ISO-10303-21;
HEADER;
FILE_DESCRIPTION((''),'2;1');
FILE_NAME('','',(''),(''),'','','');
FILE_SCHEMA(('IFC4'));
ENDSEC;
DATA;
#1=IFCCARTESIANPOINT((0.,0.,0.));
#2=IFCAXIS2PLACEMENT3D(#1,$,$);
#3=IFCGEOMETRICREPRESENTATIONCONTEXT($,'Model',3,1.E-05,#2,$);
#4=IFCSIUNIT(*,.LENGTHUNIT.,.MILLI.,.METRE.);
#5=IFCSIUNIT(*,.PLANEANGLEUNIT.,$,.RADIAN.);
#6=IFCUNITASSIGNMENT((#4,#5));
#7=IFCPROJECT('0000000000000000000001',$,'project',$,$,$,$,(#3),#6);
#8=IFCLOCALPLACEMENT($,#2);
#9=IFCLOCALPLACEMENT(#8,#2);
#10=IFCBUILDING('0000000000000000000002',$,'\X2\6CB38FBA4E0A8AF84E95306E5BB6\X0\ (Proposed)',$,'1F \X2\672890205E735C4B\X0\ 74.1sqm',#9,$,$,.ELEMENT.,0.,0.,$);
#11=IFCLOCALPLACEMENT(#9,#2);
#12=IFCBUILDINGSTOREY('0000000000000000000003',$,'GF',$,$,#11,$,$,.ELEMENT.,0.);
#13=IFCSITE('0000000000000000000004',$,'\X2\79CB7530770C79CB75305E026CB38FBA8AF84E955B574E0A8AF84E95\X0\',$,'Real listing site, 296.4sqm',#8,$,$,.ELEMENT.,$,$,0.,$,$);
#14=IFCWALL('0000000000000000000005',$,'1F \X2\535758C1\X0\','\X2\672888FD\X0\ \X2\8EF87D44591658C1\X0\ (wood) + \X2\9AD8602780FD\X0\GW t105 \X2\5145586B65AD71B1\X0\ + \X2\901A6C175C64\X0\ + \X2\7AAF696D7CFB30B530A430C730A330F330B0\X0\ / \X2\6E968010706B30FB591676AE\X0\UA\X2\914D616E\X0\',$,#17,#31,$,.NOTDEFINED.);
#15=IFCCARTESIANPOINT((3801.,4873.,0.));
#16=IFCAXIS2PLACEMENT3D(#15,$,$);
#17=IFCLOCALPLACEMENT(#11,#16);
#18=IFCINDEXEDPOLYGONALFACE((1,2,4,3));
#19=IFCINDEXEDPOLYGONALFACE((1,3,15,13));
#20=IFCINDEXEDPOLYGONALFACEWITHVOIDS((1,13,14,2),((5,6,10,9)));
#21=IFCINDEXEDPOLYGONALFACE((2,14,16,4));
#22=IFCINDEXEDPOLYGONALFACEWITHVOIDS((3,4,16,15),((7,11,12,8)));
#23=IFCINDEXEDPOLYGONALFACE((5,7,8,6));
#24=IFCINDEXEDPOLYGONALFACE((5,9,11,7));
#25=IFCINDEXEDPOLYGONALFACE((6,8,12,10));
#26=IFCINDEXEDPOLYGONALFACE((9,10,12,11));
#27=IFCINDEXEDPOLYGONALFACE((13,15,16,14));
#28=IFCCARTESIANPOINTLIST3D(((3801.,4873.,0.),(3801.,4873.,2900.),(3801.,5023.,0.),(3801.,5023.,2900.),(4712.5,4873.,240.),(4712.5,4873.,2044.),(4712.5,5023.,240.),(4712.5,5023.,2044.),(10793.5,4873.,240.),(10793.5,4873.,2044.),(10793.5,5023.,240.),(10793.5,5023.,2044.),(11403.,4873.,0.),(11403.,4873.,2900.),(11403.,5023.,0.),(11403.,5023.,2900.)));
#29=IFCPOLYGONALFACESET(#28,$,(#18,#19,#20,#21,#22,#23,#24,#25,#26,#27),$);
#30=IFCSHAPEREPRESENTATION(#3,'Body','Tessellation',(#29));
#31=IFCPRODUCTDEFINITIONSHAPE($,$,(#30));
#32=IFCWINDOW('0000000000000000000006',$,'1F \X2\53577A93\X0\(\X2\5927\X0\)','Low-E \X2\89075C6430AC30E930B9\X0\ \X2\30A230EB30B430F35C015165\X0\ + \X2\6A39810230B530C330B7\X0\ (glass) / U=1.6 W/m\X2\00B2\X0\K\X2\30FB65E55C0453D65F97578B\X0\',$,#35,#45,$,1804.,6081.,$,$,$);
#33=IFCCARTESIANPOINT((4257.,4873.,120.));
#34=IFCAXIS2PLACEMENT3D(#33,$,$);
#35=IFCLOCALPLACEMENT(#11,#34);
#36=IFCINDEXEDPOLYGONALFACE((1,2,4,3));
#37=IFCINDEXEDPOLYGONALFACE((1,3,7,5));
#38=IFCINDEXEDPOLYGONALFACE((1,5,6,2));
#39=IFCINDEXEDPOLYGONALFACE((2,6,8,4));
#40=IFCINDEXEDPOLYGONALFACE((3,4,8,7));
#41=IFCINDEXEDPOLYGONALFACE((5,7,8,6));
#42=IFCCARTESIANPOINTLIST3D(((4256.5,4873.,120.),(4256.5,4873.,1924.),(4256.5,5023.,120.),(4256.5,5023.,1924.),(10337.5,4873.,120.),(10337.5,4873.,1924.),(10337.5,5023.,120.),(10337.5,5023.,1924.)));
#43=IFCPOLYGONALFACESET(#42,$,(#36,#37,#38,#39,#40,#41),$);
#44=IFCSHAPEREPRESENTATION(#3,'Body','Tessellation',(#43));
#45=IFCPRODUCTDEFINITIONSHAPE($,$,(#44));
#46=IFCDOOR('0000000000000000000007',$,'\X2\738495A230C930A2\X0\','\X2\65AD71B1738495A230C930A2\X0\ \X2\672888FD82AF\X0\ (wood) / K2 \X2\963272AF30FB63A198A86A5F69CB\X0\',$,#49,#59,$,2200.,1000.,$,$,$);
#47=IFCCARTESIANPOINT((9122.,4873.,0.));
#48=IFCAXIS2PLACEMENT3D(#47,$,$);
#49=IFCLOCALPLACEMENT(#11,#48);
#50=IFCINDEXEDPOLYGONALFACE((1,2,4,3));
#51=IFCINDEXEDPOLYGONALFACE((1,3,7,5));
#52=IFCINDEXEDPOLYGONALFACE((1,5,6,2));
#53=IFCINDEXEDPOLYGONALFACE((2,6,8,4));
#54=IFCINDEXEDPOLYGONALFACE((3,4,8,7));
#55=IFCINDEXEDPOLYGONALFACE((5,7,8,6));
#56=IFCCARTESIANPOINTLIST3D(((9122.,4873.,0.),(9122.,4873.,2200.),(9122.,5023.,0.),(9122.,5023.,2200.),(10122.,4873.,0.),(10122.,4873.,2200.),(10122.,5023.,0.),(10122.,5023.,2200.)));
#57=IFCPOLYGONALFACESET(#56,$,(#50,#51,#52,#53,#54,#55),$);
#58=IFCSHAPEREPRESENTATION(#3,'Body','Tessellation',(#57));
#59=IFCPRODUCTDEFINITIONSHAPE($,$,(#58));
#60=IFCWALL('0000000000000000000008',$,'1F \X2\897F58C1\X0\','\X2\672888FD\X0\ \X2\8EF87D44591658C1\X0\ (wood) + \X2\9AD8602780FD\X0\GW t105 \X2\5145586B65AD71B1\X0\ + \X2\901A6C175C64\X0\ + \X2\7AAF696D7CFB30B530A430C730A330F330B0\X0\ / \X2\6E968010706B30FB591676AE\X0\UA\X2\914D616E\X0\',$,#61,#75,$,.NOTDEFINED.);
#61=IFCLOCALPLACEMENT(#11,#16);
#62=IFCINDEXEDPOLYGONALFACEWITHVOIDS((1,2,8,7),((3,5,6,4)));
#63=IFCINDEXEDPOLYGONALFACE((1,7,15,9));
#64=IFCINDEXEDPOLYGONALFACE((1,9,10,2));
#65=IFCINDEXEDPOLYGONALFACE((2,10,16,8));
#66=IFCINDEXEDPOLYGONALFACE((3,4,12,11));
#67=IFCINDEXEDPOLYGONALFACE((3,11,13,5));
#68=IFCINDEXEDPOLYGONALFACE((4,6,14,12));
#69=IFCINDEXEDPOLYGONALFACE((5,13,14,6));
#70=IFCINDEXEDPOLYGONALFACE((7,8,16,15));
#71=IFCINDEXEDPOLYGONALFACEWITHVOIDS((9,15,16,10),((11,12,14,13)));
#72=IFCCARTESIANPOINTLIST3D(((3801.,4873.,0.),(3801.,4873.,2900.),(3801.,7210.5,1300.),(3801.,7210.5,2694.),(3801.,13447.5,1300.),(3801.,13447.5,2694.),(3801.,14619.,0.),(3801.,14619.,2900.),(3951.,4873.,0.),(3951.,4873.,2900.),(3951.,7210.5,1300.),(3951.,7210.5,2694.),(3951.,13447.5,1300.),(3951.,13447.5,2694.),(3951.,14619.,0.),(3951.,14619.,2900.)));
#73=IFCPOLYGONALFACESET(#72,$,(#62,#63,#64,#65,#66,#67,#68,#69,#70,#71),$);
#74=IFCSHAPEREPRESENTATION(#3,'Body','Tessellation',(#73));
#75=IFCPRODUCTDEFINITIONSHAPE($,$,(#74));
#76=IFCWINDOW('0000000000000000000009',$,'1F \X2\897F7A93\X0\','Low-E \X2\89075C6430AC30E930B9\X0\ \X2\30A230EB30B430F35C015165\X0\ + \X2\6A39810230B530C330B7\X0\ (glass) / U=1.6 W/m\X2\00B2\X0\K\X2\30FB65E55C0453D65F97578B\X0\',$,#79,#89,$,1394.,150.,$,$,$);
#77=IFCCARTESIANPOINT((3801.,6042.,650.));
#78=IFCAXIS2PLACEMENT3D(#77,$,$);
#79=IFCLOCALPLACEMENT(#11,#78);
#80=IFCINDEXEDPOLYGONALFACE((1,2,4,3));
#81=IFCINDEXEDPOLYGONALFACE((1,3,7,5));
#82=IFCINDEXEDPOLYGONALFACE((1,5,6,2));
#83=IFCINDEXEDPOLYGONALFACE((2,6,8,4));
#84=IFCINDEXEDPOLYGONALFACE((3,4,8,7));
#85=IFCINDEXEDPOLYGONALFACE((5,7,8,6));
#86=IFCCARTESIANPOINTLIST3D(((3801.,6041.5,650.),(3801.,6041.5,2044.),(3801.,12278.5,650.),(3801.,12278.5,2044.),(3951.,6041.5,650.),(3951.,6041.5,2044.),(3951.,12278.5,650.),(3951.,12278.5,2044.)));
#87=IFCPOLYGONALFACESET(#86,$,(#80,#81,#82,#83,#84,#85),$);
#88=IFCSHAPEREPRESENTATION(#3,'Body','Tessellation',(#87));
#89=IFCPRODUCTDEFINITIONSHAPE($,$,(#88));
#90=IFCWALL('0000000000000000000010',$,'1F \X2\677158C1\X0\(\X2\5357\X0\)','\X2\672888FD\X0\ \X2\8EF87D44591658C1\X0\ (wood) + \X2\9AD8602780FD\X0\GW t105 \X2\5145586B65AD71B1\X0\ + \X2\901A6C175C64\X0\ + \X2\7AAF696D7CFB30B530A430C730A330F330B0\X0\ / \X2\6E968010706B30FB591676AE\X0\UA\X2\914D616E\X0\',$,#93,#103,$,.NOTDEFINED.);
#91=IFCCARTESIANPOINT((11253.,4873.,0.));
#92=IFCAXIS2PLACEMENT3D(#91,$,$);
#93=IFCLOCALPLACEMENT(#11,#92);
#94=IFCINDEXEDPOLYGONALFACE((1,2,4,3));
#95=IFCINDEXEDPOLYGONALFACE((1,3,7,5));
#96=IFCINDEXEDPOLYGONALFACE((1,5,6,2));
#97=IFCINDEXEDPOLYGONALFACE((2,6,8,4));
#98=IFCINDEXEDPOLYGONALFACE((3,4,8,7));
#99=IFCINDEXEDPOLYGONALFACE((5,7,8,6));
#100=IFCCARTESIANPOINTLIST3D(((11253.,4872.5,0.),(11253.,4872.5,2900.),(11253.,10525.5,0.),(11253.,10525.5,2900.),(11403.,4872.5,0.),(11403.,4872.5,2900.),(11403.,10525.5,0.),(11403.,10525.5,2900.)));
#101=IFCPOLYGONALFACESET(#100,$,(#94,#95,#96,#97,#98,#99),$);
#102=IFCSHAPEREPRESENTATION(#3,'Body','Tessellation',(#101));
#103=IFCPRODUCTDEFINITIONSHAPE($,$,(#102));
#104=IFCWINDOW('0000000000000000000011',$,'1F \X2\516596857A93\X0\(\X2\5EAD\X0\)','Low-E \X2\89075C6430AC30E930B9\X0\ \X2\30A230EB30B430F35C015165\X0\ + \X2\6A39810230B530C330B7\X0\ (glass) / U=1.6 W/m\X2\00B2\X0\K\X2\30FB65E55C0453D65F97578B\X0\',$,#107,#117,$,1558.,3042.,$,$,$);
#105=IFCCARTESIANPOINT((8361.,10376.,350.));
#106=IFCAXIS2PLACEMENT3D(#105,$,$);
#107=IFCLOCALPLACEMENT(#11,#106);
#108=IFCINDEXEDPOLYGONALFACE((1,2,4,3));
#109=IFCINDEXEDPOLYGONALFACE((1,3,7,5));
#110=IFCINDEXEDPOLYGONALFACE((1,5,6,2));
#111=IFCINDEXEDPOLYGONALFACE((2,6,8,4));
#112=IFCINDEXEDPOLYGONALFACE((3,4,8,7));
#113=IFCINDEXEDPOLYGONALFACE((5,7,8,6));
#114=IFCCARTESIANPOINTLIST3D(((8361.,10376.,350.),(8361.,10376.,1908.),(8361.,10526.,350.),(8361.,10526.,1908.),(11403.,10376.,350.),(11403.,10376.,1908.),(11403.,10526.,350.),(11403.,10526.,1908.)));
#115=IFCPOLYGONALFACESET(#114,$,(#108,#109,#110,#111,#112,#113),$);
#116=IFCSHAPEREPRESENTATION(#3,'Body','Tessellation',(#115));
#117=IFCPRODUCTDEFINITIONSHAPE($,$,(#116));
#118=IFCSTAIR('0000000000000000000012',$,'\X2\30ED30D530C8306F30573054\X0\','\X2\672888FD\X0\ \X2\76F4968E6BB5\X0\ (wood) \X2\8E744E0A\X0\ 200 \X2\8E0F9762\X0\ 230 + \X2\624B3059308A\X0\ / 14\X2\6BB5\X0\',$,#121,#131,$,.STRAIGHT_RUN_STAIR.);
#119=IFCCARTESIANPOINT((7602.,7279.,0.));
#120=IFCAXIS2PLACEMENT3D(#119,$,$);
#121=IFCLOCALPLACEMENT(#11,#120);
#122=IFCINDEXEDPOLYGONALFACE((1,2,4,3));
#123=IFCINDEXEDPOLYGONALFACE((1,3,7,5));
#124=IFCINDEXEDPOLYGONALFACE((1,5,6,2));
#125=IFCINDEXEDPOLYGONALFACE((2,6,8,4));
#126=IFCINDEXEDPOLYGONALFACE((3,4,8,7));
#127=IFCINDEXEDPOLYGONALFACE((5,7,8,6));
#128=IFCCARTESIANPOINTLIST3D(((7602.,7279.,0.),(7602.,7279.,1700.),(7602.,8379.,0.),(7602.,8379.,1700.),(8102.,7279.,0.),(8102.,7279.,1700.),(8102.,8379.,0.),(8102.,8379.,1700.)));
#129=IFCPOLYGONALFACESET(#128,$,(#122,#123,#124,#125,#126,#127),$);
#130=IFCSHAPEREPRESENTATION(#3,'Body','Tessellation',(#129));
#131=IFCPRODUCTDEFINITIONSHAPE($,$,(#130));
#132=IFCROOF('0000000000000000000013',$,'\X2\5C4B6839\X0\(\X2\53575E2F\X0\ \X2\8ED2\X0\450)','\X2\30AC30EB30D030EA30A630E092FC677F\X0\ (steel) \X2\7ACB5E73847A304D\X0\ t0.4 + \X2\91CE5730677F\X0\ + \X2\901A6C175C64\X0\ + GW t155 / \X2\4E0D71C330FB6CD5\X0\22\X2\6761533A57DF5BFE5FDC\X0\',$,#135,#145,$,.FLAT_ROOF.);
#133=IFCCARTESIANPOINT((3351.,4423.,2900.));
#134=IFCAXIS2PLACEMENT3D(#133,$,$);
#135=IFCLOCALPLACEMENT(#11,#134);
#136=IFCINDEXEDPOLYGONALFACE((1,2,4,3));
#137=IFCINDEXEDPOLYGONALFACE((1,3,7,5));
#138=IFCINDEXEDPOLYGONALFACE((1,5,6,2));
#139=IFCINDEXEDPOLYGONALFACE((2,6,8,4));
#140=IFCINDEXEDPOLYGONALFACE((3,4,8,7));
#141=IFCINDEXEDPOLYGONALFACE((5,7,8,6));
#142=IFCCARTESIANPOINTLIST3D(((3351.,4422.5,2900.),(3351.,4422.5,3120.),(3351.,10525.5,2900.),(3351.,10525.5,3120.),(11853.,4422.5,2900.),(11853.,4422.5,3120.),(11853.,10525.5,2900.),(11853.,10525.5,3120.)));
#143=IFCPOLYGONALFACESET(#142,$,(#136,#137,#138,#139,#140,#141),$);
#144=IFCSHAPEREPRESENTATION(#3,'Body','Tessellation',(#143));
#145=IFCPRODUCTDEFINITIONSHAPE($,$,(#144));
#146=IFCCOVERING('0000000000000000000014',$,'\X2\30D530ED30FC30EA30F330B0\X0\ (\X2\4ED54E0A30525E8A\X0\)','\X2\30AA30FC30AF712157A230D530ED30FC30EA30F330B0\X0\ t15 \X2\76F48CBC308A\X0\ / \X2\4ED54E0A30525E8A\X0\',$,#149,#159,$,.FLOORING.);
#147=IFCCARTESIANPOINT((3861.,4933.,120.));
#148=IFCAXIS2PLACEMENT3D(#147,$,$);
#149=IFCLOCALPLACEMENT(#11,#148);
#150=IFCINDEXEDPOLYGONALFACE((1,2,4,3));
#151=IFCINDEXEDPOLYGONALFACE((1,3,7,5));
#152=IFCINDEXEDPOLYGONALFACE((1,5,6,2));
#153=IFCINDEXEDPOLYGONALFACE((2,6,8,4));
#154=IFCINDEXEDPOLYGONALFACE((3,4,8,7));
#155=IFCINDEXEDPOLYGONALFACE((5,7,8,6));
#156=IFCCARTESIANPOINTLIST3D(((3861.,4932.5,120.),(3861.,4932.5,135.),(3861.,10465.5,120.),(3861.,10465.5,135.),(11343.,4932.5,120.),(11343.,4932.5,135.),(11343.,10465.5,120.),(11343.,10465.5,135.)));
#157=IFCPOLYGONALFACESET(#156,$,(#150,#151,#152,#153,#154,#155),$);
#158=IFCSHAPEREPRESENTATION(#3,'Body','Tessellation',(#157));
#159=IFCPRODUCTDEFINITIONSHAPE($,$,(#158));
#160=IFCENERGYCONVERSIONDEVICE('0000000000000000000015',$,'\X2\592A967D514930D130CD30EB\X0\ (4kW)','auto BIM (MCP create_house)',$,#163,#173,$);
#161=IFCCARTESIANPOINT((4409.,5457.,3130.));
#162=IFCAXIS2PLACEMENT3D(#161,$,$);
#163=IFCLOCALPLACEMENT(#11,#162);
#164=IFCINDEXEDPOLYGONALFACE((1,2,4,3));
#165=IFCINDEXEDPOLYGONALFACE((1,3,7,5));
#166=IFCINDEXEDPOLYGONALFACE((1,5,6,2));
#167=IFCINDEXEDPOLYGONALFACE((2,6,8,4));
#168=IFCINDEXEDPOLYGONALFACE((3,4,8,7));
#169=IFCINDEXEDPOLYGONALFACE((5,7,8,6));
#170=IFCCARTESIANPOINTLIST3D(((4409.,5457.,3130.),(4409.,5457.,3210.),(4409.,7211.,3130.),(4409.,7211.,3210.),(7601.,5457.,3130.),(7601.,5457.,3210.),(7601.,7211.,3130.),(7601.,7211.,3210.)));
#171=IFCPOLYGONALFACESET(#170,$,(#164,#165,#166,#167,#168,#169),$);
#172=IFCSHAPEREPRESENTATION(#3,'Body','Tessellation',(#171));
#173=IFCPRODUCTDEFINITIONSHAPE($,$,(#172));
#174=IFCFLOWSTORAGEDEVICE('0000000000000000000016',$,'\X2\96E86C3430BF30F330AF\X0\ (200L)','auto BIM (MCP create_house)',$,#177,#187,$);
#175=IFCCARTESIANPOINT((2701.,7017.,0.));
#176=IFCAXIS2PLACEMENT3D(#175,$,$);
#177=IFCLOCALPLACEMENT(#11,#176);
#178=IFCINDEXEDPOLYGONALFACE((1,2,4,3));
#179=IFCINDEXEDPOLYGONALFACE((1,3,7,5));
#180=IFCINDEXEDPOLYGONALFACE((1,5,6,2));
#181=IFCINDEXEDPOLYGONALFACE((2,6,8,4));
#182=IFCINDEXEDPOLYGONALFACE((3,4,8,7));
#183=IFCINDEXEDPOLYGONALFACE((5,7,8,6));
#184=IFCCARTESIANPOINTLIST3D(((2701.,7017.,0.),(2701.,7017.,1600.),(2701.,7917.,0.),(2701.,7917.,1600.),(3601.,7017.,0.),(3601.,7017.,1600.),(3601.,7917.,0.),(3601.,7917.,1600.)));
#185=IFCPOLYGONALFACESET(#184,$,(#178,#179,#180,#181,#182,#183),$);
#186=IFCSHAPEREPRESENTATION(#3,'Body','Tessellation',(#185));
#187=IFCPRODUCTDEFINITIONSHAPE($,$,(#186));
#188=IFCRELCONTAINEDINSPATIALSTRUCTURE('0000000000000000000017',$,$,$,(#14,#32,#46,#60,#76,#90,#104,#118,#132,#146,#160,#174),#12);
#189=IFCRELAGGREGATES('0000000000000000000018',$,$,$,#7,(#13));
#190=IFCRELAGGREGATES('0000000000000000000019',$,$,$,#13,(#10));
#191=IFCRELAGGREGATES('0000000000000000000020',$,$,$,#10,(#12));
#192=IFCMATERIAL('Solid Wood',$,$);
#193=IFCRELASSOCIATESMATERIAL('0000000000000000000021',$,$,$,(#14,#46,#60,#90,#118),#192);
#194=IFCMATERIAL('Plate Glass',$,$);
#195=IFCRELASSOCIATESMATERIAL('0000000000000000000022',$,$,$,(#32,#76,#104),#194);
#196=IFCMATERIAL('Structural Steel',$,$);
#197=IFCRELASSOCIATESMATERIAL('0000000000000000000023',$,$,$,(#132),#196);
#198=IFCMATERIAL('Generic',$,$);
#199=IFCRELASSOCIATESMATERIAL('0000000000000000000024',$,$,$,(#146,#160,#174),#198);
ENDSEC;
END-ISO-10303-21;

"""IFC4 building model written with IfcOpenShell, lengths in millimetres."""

from ifc_helpers import new_model, si_unit, frame, frame_2d, origin, place, context, project, spatial, rectangle, extrude, material, element, fill, save


model = new_model("IFC4")

# Units and contexts
model_context = context("Model", 3, precision=1e-05, world=origin())
ifc_project = project(units=[si_unit("LENGTHUNIT", "METRE", prefix="MILLI"), si_unit("PLANEANGLEUNIT", "RADIAN")], contexts=[model_context])

# Site, building, storey
site_placement = place(None, origin())
site = spatial("IfcSite", under=ifc_project, at=site_placement, Name="秋田県秋田市河辺諸井字上諸井", ObjectType="Real listing site, 296.4sqm", CompositionType="ELEMENT", RefElevation=0.0)
building_placement = place(site_placement, origin())
building = spatial("IfcBuilding", under=site, at=building_placement, Name="河辺上諸井の家 (Proposed)", ObjectType="1F 木造平屋 74.1sqm", CompositionType="ELEMENT", ElevationOfRefHeight=0.0, ElevationOfTerrain=0.0)
storey_placement = place(building_placement, origin())
storey = spatial("IfcBuildingStorey", under=building, at=storey_placement, Name="GF", CompositionType="ELEMENT", Elevation=0.0)

# Shared definitions
ifc_material_1 = material(Name="Solid Wood")

# Wall, openings, window, door
wall_1_placement = place(storey_placement, frame((3801.0, 4873.0, 0.0)))
wall_1 = element("IfcWall", 1, at=wall_1_placement, inside=storey, material=ifc_material_1, Name="1F 南壁", Description="木製 軸組外壁 (wood) + 高性能GW t105 充填断熱 + 通気層 + 窯業系サイディング / 準耐火・外皮UA配慮", PredefinedType="NOTDEFINED", context=model_context, shape_type="SweptSolid", body=[
    extrude(rectangle(XDim=7602.0, YDim=150.0, at=frame_2d((3801.0, 75.0))), frame((3801.0, 4873.0, 0.0)), (0.0, 0.0, 1.0), 2900.0),
])
opening_1_placement = place(storey_placement, frame((4257.0, 4873.0, 120.0)))
opening_1 = element("IfcOpeningElement", 2, at=opening_1_placement, cuts=wall_1, PredefinedType="NOTDEFINED", context=model_context, shape_type="SweptSolid", body=[
    extrude(rectangle(XDim=6081.0, YDim=150.0, at=frame_2d((3040.0, 75.0))), frame((4257.0, 4873.0, 120.0)), (0.0, 0.0, 1.0), 1804.0),
])
opening_2_placement = place(storey_placement, frame((9122.0, 4873.0, 0.0)))
opening_2 = element("IfcOpeningElement", 3, at=opening_2_placement, cuts=wall_1, PredefinedType="NOTDEFINED", context=model_context, shape_type="SweptSolid", body=[
    extrude(rectangle(XDim=1000.0, YDim=150.0, at=frame_2d((500.0, 75.0))), frame((9122.0, 4873.0, 0.0)), (0.0, 0.0, 1.0), 2200.0),
])
ifc_material_2 = material(Name="Plate Glass")
window_1_placement = place(storey_placement, frame((4257.0, 4873.0, 120.0)))
window_1 = element("IfcWindow", 4, at=window_1_placement, inside=storey, material=ifc_material_2, Name="1F 南窓(大)", Description="Low-E 複層ガラス アルゴン封入 + 樹脂サッシ (glass) / U=1.6 W/m²K・日射取得型", OverallHeight=1804.0, OverallWidth=6081.0, context=model_context, shape_type="SweptSolid", body=[
    extrude(rectangle(XDim=6081.0, YDim=150.0, at=frame_2d((3040.0, 75.0))), frame((4257.0, 4873.0, 120.0)), (0.0, 0.0, 1.0), 1804.0),
])
fill(opening_1, window_1)
door_1_placement = place(storey_placement, frame((9122.0, 4873.0, 0.0)))
door_1 = element("IfcDoor", 5, at=door_1_placement, inside=storey, material=ifc_material_1, Name="玄関ドア", Description="断熱玄関ドア 木製芯 (wood) / K2 防犯・採風機構", OverallHeight=2200.0, OverallWidth=1000.0, context=model_context, shape_type="SweptSolid", body=[
    extrude(rectangle(XDim=1000.0, YDim=150.0, at=frame_2d((500.0, 75.0))), frame((9122.0, 4873.0, 0.0)), (0.0, 0.0, 1.0), 2200.0),
])
fill(opening_2, door_1)

# Walls, openings, windows
wall_2_placement = place(storey_placement, frame((3801.0, 4873.0, 0.0)))
wall_2 = element("IfcWall", 6, at=wall_2_placement, inside=storey, material=ifc_material_1, Name="1F 西壁", Description="木製 軸組外壁 (wood) + 高性能GW t105 充填断熱 + 通気層 + 窯業系サイディング / 準耐火・外皮UA配慮", PredefinedType="NOTDEFINED", context=model_context, shape_type="SweptSolid", body=[
    extrude(rectangle(XDim=150.0, YDim=9746.0, at=frame_2d((75.0, 4873.0))), frame((3801.0, 4873.0, 0.0)), (0.0, 0.0, 1.0), 2900.0),
])
opening_3_placement = place(storey_placement, frame((3801.0, 6042.0, 650.0)))
opening_3 = element("IfcOpeningElement", 7, at=opening_3_placement, cuts=wall_2, PredefinedType="NOTDEFINED", context=model_context, shape_type="SweptSolid", body=[
    extrude(rectangle(XDim=150.0, YDim=6237.0, at=frame_2d((75.0, 3118.0))), frame((3801.0, 6042.0, 650.0)), (0.0, 0.0, 1.0), 1394.0),
])
window_2_placement = place(storey_placement, frame((3801.0, 6042.0, 650.0)))
window_2 = element("IfcWindow", 8, at=window_2_placement, inside=storey, material=ifc_material_2, Name="1F 西窓", Description="Low-E 複層ガラス アルゴン封入 + 樹脂サッシ (glass) / U=1.6 W/m²K・日射取得型", OverallHeight=1394.0, OverallWidth=150.0, context=model_context, shape_type="SweptSolid", body=[
    extrude(rectangle(XDim=150.0, YDim=6237.0, at=frame_2d((75.0, 3118.0))), frame((3801.0, 6042.0, 650.0)), (0.0, 0.0, 1.0), 1394.0),
])
fill(opening_3, window_2)
wall_3_placement = place(storey_placement, frame((11253.0, 4873.0, 0.0)))
wall_3 = element("IfcWall", 9, at=wall_3_placement, inside=storey, material=ifc_material_1, Name="1F 東壁(南)", Description="木製 軸組外壁 (wood) + 高性能GW t105 充填断熱 + 通気層 + 窯業系サイディング / 準耐火・外皮UA配慮", PredefinedType="NOTDEFINED", context=model_context, shape_type="SweptSolid", body=[
    extrude(rectangle(XDim=150.0, YDim=5653.0, at=frame_2d((75.0, 2826.0))), frame((11253.0, 4873.0, 0.0)), (0.0, 0.0, 1.0), 2900.0),
])
opening_4_placement = place(storey_placement, frame((8361.0, 10376.0, 350.0)))
opening_4 = element("IfcOpeningElement", 10, at=opening_4_placement, cuts=wall_3, PredefinedType="NOTDEFINED", context=model_context, shape_type="SweptSolid", body=[
    extrude(rectangle(XDim=3042.0, YDim=150.0, at=frame_2d((1521.0, 75.0))), frame((8361.0, 10376.0, 350.0)), (0.0, 0.0, 1.0), 1558.0),
])
window_3_placement = place(storey_placement, frame((8361.0, 10376.0, 350.0)))
window_3 = element("IfcWindow", 11, at=window_3_placement, inside=storey, material=ifc_material_2, Name="1F 入隅窓(庭)", Description="Low-E 複層ガラス アルゴン封入 + 樹脂サッシ (glass) / U=1.6 W/m²K・日射取得型", OverallHeight=1558.0, OverallWidth=3042.0, context=model_context, shape_type="SweptSolid", body=[
    extrude(rectangle(XDim=3042.0, YDim=150.0, at=frame_2d((1521.0, 75.0))), frame((8361.0, 10376.0, 350.0)), (0.0, 0.0, 1.0), 1558.0),
])
fill(opening_4, window_3)

# Stair
stair_placement = place(storey_placement, frame((7602.0, 7279.0, 0.0)))
element("IfcStair", 12, at=stair_placement, inside=storey, material=ifc_material_1, Name="ロフトはしご", Description="木製 直階段 (wood) 蹴上 200 踏面 230 + 手すり / 14段", PredefinedType="STRAIGHT_RUN_STAIR", context=model_context, shape_type="SweptSolid", body=[
    extrude(rectangle(XDim=500.0, YDim=1100.0, at=frame_2d((250.0, 550.0))), frame((7602.0, 7279.0, 0.0)), (0.0, 0.0, 1.0), 1700.0),
])

# Roof
ifc_material_3 = material(Name="Structural Steel")
roof_placement = place(storey_placement, frame((3351.0, 4423.0, 2900.0)))
element("IfcRoof", 13, at=roof_placement, inside=storey, material=ifc_material_3, Name="屋根(南帯 軒450)", Description="ガルバリウム鋼板 (steel) 立平葺き t0.4 + 野地板 + 通気層 + GW t155 / 不燃・法22条区域対応", PredefinedType="FLAT_ROOF", context=model_context, shape_type="SweptSolid", body=[
    extrude(rectangle(XDim=8502.0, YDim=6103.0, at=frame_2d((4251.0, 3051.0))), frame((3351.0, 4423.0, 2900.0)), (0.0, 0.0, 1.0), 220.0),
])

# Covering
ifc_material_4 = material(Name="Generic")
covering_placement = place(storey_placement, frame((3861.0, 4933.0, 120.0)))
element("IfcCovering", 14, at=covering_placement, inside=storey, material=ifc_material_4, Name="フローリング (仕上げ床)", Description="オーク無垢フローリング t15 直貼り / 仕上げ床", PredefinedType="FLOORING", context=model_context, shape_type="SweptSolid", body=[
    extrude(rectangle(XDim=7482.0, YDim=5533.0, at=frame_2d((3741.0, 2766.0))), frame((3861.0, 4933.0, 120.0)), (0.0, 0.0, 1.0), 15.0),
])

# Energy conversion device
energy_conversion_device_placement = place(storey_placement, frame((4409.0, 5457.0, 3130.0)))
element("IfcEnergyConversionDevice", 15, at=energy_conversion_device_placement, inside=storey, material=ifc_material_4, Name="太陽光パネル (4kW)", Description="auto BIM (MCP create_house)", context=model_context, shape_type="SweptSolid", body=[
    extrude(rectangle(XDim=3192.0, YDim=1754.0, at=frame_2d((1596.0, 877.0))), frame((4409.0, 5457.0, 3130.0)), (0.0, 0.0, 1.0), 80.0),
])

# Flow storage device
flow_storage_device_placement = place(storey_placement, frame((2701.0, 7017.0, 0.0)))
element("IfcFlowStorageDevice", 16, at=flow_storage_device_placement, inside=storey, material=ifc_material_4, Name="雨水タンク (200L)", Description="auto BIM (MCP create_house)", context=model_context, shape_type="SweptSolid", body=[
    extrude(rectangle(XDim=900.0, YDim=900.0, at=frame_2d((450.0, 450.0))), frame((2701.0, 7017.0, 0.0)), (0.0, 0.0, 1.0), 1600.0),
])

save(model, "model.ifc")
